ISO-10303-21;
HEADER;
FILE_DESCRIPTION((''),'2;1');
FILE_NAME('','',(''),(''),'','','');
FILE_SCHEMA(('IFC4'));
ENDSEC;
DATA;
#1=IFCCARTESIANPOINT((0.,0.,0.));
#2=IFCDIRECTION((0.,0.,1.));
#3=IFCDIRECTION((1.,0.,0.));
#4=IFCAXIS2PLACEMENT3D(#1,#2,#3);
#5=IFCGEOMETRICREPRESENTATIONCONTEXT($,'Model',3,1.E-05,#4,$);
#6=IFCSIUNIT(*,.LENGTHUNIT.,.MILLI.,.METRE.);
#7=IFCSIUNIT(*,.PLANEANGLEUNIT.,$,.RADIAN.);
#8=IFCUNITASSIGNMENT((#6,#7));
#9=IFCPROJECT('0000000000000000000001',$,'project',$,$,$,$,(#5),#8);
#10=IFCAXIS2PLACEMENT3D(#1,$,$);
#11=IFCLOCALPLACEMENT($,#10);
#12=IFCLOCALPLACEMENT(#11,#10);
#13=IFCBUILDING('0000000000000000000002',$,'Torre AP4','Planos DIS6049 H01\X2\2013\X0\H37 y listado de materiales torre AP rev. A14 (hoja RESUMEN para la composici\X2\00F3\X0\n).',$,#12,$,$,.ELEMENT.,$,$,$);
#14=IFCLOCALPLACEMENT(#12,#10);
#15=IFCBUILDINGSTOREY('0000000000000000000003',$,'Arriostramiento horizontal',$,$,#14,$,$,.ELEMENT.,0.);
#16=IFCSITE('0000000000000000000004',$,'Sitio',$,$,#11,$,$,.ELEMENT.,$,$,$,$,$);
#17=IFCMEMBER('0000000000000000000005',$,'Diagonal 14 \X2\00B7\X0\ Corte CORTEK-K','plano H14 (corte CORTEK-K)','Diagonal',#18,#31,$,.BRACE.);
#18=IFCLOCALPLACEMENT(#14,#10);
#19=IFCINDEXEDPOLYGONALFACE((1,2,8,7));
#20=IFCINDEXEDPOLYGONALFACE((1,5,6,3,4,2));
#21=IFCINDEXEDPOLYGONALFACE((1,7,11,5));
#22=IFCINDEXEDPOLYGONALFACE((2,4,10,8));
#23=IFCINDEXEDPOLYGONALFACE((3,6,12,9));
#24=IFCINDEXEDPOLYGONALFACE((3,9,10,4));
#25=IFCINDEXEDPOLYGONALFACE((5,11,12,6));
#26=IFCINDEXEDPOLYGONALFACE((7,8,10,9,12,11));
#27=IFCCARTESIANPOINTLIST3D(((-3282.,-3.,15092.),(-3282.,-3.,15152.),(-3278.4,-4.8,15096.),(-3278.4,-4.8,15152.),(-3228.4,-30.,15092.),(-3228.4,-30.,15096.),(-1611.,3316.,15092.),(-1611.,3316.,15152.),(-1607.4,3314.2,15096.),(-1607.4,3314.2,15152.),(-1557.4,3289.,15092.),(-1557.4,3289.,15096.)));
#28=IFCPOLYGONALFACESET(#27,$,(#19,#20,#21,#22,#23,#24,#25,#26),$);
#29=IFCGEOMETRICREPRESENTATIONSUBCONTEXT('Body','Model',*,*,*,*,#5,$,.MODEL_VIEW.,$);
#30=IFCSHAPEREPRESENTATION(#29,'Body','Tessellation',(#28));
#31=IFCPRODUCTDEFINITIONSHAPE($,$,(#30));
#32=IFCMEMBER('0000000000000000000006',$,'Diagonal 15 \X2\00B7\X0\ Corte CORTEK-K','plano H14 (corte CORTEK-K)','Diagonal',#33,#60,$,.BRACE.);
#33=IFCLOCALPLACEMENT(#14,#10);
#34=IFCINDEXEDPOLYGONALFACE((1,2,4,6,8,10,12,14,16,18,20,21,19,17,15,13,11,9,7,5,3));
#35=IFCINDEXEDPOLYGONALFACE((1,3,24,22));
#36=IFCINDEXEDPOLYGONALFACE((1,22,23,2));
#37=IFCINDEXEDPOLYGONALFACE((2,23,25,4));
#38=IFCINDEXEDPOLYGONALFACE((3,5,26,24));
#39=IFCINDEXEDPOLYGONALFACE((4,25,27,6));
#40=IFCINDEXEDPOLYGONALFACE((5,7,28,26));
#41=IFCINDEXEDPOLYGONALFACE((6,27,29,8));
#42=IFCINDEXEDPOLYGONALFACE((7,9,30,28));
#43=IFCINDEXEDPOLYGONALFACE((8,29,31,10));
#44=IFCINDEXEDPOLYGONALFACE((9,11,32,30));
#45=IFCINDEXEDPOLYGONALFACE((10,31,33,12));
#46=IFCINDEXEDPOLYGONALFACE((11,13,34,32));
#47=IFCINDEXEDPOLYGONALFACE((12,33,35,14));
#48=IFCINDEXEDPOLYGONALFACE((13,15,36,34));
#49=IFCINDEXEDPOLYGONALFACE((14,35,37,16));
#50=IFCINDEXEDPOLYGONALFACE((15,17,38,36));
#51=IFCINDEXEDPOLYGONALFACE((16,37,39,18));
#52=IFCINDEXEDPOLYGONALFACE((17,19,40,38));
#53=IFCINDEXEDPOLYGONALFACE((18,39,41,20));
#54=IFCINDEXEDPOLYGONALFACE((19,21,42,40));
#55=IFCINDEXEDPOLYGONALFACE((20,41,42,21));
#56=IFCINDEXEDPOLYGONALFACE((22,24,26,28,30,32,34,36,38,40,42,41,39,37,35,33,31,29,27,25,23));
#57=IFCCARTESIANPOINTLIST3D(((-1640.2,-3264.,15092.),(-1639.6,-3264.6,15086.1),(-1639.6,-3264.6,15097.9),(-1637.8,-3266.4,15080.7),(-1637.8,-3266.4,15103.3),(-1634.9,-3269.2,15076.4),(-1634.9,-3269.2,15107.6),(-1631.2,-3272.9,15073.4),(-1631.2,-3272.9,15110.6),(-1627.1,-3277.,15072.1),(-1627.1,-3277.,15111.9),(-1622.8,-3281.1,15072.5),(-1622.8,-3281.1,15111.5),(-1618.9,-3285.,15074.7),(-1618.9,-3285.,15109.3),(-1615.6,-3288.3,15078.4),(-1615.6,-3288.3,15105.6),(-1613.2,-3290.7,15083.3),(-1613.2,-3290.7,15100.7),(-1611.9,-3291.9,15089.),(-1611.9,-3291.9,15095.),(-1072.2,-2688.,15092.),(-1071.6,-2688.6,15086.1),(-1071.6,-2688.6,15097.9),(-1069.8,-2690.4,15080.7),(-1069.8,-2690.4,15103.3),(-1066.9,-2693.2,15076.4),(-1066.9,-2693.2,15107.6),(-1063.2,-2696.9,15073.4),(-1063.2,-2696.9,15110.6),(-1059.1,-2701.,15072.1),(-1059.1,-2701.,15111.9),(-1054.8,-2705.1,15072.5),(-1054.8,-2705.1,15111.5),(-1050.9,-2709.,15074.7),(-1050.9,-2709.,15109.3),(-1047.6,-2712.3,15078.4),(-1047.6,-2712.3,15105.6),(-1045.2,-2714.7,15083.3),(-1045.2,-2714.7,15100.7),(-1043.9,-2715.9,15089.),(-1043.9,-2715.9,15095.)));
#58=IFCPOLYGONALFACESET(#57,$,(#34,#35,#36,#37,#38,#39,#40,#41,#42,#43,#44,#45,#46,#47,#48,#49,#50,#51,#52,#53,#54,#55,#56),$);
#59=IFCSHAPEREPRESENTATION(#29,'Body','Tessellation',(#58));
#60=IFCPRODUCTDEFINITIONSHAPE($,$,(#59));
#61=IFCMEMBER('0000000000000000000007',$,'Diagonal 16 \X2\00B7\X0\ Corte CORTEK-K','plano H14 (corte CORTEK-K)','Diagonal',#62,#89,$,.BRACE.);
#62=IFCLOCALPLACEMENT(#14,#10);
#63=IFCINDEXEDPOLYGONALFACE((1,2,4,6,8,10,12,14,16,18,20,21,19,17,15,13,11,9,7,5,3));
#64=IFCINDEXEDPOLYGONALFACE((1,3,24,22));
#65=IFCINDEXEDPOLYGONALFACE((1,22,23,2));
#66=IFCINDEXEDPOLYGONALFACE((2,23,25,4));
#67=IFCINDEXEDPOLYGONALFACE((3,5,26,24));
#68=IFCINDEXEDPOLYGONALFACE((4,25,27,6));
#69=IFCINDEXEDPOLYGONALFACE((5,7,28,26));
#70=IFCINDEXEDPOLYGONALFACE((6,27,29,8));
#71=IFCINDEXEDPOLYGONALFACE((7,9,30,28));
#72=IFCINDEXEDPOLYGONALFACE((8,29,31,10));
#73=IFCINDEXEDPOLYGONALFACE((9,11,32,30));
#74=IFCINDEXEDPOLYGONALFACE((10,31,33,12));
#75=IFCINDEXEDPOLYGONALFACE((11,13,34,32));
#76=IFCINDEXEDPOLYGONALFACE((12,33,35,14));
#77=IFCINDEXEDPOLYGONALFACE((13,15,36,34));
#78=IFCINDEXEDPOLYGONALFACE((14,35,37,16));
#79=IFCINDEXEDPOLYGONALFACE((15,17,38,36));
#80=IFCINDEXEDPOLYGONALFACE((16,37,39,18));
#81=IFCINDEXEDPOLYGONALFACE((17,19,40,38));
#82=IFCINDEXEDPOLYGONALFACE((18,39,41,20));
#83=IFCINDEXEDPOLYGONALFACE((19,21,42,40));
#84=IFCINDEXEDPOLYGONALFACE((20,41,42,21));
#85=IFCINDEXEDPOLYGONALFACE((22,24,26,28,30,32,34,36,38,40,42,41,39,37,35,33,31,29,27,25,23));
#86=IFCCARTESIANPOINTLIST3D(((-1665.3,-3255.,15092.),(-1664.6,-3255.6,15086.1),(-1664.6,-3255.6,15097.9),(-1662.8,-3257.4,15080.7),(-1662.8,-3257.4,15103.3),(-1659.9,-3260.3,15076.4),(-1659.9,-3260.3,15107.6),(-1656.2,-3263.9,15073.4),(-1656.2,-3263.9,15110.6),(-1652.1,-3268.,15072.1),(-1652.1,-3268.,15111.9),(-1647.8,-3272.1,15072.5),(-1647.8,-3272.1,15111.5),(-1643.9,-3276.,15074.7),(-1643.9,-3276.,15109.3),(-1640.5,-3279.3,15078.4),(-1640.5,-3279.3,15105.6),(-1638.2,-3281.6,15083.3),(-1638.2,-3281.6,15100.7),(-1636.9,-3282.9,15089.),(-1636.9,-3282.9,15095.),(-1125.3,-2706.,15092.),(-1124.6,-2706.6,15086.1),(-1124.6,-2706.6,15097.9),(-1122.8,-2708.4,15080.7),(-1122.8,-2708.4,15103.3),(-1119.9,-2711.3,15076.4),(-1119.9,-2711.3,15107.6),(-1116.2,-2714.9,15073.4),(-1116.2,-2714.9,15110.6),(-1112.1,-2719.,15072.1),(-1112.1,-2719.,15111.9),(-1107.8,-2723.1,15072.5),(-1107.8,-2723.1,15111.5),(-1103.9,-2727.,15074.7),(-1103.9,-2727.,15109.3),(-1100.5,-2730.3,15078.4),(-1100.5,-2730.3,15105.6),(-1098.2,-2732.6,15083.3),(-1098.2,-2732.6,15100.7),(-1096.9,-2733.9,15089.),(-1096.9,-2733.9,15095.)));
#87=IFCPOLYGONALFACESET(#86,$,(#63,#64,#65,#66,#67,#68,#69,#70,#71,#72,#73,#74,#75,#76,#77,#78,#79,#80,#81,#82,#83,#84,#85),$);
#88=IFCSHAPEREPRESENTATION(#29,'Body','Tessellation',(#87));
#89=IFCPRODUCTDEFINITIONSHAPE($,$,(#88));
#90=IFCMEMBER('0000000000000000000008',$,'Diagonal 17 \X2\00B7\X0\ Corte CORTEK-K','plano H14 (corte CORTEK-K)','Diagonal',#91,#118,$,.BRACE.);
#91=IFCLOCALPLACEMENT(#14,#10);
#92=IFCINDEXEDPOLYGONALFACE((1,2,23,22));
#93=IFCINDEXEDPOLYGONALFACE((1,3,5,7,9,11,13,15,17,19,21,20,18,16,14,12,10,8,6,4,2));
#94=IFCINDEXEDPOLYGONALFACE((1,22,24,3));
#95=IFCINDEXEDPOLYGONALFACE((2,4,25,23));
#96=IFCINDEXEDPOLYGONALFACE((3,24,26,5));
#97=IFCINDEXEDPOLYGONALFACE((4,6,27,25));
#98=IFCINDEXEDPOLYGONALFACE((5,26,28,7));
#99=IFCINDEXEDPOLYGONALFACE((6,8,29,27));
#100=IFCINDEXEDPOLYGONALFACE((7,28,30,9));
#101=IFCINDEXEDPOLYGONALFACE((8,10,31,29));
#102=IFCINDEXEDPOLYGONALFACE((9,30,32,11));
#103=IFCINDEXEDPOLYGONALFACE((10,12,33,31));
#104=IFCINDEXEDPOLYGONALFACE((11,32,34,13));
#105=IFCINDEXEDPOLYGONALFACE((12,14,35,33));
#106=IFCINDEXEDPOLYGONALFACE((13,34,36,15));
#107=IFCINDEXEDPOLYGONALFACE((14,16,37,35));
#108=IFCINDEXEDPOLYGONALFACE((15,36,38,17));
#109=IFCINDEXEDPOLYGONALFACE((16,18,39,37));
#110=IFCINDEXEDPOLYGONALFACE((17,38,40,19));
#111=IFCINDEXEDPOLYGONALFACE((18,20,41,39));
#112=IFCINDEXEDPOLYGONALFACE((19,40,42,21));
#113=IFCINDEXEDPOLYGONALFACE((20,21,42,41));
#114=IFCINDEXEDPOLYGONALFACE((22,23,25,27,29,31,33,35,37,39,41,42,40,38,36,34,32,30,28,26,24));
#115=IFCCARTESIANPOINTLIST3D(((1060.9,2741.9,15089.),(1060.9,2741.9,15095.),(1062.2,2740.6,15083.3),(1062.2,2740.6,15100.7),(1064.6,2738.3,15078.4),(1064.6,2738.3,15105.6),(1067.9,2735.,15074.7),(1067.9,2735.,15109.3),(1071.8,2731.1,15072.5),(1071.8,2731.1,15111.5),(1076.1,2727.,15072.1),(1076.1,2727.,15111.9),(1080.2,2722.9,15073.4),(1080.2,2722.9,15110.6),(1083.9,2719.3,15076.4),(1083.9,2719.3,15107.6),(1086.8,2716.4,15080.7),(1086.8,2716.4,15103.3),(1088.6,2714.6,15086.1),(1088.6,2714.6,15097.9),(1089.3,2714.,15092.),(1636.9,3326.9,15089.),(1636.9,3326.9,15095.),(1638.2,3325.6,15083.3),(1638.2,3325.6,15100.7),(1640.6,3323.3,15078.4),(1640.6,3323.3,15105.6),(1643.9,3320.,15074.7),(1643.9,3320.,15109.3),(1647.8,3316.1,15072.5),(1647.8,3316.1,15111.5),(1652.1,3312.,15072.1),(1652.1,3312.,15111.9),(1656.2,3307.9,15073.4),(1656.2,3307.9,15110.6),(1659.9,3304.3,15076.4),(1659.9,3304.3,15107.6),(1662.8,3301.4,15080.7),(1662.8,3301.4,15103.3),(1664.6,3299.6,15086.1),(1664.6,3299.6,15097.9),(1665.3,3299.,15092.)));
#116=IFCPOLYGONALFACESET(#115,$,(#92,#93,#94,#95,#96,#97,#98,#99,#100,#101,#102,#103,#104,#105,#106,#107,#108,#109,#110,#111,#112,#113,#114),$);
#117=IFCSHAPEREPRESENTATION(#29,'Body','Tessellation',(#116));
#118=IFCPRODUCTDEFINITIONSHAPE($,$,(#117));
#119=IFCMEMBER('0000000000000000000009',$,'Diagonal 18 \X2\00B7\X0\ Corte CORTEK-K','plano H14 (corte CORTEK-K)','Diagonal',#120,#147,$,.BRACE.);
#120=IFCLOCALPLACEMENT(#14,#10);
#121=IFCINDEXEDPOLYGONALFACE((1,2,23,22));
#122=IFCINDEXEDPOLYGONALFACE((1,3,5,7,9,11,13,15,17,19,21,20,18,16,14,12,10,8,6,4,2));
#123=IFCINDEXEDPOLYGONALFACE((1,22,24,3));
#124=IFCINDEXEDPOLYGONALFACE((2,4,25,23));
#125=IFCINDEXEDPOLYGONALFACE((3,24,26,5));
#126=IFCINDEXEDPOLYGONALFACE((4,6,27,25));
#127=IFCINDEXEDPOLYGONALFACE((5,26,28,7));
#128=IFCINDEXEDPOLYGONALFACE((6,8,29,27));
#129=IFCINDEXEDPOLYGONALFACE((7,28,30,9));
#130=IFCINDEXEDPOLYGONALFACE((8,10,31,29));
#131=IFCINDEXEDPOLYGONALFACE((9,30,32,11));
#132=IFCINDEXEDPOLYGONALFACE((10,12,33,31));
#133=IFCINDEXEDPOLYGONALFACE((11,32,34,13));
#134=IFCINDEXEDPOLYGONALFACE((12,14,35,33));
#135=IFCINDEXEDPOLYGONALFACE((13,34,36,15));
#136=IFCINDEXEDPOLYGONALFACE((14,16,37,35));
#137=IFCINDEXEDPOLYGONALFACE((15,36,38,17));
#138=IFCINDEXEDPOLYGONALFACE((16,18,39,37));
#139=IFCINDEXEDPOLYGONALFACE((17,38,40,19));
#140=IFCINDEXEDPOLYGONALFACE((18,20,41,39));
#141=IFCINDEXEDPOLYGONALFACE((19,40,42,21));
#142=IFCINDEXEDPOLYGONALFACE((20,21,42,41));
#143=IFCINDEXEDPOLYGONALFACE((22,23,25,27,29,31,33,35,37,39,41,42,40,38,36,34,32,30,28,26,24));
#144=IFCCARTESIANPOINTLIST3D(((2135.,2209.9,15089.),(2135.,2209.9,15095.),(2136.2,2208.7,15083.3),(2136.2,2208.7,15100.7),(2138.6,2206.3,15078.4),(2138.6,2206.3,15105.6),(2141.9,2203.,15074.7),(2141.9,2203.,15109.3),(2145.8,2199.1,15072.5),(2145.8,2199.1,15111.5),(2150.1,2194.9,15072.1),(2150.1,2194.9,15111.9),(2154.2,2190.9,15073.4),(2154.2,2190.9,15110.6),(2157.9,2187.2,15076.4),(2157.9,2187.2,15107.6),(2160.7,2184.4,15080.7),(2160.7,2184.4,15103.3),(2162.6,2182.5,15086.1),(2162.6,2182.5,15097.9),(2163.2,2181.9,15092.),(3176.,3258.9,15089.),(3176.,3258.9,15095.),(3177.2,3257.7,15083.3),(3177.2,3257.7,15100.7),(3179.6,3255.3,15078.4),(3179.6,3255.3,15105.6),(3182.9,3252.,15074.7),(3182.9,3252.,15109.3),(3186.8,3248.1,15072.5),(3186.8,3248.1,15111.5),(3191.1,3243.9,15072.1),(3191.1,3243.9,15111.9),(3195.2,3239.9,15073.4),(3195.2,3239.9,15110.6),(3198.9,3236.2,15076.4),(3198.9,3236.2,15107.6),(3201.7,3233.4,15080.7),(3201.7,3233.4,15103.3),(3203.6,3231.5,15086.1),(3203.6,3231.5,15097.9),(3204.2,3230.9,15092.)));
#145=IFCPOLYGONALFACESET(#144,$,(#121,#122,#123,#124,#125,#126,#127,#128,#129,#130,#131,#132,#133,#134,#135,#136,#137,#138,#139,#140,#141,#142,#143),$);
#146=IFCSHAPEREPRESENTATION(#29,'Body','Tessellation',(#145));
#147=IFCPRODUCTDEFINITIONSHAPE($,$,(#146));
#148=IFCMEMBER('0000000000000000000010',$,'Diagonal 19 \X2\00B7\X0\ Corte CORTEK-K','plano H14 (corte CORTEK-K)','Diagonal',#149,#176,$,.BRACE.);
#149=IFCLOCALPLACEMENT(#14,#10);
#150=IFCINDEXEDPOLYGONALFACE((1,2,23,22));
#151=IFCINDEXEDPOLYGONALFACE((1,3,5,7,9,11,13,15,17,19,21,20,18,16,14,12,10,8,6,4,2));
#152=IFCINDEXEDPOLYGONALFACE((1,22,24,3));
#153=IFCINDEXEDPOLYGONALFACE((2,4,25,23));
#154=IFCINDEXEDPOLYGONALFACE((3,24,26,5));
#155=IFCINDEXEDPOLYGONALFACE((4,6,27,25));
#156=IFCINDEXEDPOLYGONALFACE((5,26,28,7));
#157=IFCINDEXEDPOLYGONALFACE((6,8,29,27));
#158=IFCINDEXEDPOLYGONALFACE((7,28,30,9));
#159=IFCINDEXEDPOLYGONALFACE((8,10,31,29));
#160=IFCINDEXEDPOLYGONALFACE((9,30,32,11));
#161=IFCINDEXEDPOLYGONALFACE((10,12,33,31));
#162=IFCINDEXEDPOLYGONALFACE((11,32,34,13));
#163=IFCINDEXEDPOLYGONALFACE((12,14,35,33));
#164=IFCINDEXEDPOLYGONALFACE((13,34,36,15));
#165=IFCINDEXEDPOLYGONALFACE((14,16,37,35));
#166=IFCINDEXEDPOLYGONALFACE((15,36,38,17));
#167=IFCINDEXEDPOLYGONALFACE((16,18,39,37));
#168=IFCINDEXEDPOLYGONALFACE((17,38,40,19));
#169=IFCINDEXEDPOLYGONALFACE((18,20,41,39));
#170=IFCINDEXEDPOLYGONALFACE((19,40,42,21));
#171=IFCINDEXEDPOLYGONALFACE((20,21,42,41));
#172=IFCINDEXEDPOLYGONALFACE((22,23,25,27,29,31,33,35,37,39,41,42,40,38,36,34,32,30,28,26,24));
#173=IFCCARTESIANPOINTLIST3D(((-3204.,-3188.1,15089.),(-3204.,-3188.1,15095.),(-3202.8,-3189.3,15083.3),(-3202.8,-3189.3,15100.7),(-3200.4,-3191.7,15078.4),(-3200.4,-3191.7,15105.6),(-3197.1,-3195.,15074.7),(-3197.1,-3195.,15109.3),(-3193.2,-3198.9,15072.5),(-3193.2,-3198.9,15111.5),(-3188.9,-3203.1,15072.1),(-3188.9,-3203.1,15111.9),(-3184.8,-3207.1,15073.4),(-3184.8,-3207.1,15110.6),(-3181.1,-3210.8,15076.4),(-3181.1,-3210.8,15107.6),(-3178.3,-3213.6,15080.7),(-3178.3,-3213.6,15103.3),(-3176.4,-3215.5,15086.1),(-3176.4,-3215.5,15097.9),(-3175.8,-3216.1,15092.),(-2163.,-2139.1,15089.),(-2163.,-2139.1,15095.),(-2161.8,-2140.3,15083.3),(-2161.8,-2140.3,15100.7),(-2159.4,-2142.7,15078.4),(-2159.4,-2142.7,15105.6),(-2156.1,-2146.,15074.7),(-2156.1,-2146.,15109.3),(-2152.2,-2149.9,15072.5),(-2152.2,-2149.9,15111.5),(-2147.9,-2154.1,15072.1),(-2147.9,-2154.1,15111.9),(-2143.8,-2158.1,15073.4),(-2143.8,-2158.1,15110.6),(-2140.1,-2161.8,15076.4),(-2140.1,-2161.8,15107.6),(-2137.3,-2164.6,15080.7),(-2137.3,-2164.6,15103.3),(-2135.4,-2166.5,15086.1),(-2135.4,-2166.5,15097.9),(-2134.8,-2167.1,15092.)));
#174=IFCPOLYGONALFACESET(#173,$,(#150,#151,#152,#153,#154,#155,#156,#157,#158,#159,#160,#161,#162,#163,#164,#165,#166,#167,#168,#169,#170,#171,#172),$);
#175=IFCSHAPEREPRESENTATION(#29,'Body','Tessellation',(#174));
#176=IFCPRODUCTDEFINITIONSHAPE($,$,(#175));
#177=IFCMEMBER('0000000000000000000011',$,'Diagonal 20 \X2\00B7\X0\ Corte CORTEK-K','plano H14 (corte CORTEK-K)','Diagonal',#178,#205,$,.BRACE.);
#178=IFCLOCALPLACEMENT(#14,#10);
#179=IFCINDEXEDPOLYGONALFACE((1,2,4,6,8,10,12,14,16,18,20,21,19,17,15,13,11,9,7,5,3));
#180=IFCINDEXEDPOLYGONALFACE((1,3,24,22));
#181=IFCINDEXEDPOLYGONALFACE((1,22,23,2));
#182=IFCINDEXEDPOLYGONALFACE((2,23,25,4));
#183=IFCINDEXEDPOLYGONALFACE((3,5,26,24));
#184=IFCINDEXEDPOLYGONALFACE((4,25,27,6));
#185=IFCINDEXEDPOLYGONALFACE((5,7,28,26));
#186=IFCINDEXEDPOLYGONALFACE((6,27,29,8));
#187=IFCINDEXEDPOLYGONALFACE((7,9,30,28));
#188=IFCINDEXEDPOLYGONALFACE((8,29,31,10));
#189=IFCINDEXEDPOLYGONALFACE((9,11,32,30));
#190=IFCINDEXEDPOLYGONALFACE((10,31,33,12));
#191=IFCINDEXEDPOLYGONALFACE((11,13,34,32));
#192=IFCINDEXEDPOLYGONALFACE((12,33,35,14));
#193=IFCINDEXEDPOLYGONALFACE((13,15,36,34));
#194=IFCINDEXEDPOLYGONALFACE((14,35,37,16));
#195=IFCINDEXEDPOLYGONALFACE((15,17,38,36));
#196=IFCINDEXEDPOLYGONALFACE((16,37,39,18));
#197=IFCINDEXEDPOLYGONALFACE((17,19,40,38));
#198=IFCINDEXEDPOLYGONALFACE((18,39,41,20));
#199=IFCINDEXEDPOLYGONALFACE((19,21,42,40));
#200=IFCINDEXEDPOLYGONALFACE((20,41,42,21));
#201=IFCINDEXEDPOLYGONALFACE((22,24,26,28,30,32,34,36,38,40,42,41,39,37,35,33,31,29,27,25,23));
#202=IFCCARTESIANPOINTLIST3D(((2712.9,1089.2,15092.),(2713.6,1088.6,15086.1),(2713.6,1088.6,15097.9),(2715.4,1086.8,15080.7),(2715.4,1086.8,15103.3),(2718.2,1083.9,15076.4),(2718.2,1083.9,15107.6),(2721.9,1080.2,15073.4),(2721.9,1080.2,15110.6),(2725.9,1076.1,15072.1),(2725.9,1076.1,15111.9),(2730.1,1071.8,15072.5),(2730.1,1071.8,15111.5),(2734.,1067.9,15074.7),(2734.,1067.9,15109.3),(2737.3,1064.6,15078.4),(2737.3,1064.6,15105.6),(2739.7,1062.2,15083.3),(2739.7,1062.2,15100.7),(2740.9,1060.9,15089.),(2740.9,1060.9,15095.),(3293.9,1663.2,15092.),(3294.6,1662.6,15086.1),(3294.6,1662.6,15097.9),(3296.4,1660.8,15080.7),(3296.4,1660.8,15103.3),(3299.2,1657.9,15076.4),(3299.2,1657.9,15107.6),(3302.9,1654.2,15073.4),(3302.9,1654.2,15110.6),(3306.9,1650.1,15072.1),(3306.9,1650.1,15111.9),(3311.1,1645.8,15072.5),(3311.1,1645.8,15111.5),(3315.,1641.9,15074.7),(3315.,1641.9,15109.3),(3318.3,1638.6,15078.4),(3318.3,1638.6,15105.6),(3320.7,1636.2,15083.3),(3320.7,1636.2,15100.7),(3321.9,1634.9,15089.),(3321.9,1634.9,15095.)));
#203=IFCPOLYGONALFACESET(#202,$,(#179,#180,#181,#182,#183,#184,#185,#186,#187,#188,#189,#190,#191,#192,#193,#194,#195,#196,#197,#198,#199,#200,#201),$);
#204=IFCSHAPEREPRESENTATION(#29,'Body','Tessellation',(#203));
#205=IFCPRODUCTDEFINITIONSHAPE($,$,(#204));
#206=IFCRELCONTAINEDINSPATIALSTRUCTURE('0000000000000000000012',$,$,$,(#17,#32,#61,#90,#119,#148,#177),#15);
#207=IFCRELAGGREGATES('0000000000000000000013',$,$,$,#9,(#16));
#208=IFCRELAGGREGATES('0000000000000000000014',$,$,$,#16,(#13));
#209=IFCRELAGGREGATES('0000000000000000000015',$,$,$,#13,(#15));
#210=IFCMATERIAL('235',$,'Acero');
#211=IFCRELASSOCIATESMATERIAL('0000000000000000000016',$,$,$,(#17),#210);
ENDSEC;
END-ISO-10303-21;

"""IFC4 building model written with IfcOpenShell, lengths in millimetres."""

from ifc_helpers import new_model, si_unit, frame, frame_2d, origin, origin_with_axes, place, context, subcontext, project, spatial, circle, l_section, extrude, material, element, save


model = new_model("IFC4")

# Units and contexts
model_context = context("Model", 3, precision=1e-05, world=origin_with_axes())
body_context = subcontext(model_context, "Body", "Model", "MODEL_VIEW")
ifc_project = project(units=[si_unit("LENGTHUNIT", "METRE", prefix="MILLI"), si_unit("PLANEANGLEUNIT", "RADIAN")], contexts=[model_context])

# Site, building, storey
site_placement = place(None, origin())
site = spatial("IfcSite", under=ifc_project, at=site_placement, Name="Sitio", CompositionType="ELEMENT")
building_placement = place(site_placement, origin())
building = spatial("IfcBuilding", under=site, at=building_placement, Name="Torre AP4", Description="Planos DIS6049 H01–H37 y listado de materiales torre AP rev. A14 (hoja RESUMEN para la composición).", CompositionType="ELEMENT")
storey_placement = place(building_placement, origin())
storey = spatial("IfcBuildingStorey", under=building, at=storey_placement, Name="Arriostramiento horizontal", CompositionType="ELEMENT", Elevation=0.0)

# Members
ifc_material = material(Name="235", Category="Acero")
member_1_placement = place(storey_placement, frame((-1611.0, 3316.0, 15092.0), z_axis=(-0.449688, -0.893186, 0.0), x_axis=(0.893186, -0.449688, 0.0)))
element("IfcMember", 1, at=member_1_placement, inside=storey, material=ifc_material, Name="Diagonal 14 · Corte CORTEK-K", Description="plano H14 (corte CORTEK-K)", ObjectType="Diagonal", PredefinedType="BRACE", context=body_context, shape_type="SweptSolid", body=[
    extrude(l_section(Depth=60.0, Width=60.0, Thickness=4.0, at=frame_2d((30.0, 30.0))), None, (0.0, 0.0, 1.0), 3715.9),
])
member_2_placement = place(storey_placement, frame((-1058.0, -2702.0, 15092.0), z_axis=(-0.702145, -0.712034, 0.0), x_axis=(-0.712034, 0.702145, 0.0)))
element("IfcMember", 2, at=member_2_placement, inside=storey, Name="Diagonal 15 · Corte CORTEK-K", Description="plano H14 (corte CORTEK-K)", ObjectType="Diagonal", PredefinedType="BRACE", context=body_context, shape_type="SweptSolid", body=[
    extrude(circle(Radius=20.0), None, (0.0, 0.0, 1.0), 808.9),
])
member_3_placement = place(storey_placement, frame((-1111.0, -2720.0, 15092.0), z_axis=(-0.701239, -0.712926, 0.0), x_axis=(-0.712926, 0.701239, 0.0)))
element("IfcMember", 3, at=member_3_placement, inside=storey, Name="Diagonal 16 · Corte CORTEK-K", Description="plano H14 (corte CORTEK-K)", ObjectType="Diagonal", PredefinedType="BRACE", context=body_context, shape_type="SweptSolid", body=[
    extrude(circle(Radius=20.0), None, (0.0, 0.0, 1.0), 770.1),
])
member_4_placement = place(storey_placement, frame((1651.0, 3313.0, 15092.0), z_axis=(-0.701604, -0.712567, 0.0), x_axis=(0.712567, -0.701604, 0.0)))
element("IfcMember", 4, at=member_4_placement, inside=storey, Name="Diagonal 17 · Corte CORTEK-K", Description="plano H14 (corte CORTEK-K)", ObjectType="Diagonal", PredefinedType="BRACE", context=body_context, shape_type="SweptSolid", body=[
    extrude(circle(Radius=20.0), None, (0.0, 0.0, 1.0), 821.0),
])
for number, where, z_axis, x_axis, name in (
    (5, (3190.0, 3245.0, 15092.0), (-0.704395, -0.709808, 0.0), (0.709808, -0.704395, 0.0), "Diagonal 18 · Corte CORTEK-K"),
    (6, (-2149.0, -2153.0, 15092.0), (-0.704395, -0.709808, 0.0), (0.709808, -0.704395, 0.0), "Diagonal 19 · Corte CORTEK-K"),
):
    element("IfcMember", number, at=place(storey_placement, frame(where, z_axis=z_axis, x_axis=x_axis)), inside=storey, Name=name, Description="plano H14 (corte CORTEK-K)", ObjectType="Diagonal", PredefinedType="BRACE", context=body_context, shape_type="SweptSolid", body=[
        extrude(circle(Radius=20.0), None, (0.0, 0.0, 1.0), 1477.9),
    ])
for number, where, z_axis, x_axis, name in (
    (7, (3308.0, 1649.0, 15092.0), (-0.711379, -0.702808, 0.0), (-0.702808, 0.711379, 0.0), "Diagonal 20 · Corte CORTEK-K"),
):
    element("IfcMember", number, at=place(storey_placement, frame(where, z_axis=z_axis, x_axis=x_axis)), inside=storey, Name=name, Description="plano H14 (corte CORTEK-K)", ObjectType="Diagonal", PredefinedType="BRACE", context=body_context, shape_type="SweptSolid", body=[
        extrude(circle(Radius=20.0), None, (0.0, 0.0, 1.0), 816.7),
    ])

save(model, "model.ifc")
